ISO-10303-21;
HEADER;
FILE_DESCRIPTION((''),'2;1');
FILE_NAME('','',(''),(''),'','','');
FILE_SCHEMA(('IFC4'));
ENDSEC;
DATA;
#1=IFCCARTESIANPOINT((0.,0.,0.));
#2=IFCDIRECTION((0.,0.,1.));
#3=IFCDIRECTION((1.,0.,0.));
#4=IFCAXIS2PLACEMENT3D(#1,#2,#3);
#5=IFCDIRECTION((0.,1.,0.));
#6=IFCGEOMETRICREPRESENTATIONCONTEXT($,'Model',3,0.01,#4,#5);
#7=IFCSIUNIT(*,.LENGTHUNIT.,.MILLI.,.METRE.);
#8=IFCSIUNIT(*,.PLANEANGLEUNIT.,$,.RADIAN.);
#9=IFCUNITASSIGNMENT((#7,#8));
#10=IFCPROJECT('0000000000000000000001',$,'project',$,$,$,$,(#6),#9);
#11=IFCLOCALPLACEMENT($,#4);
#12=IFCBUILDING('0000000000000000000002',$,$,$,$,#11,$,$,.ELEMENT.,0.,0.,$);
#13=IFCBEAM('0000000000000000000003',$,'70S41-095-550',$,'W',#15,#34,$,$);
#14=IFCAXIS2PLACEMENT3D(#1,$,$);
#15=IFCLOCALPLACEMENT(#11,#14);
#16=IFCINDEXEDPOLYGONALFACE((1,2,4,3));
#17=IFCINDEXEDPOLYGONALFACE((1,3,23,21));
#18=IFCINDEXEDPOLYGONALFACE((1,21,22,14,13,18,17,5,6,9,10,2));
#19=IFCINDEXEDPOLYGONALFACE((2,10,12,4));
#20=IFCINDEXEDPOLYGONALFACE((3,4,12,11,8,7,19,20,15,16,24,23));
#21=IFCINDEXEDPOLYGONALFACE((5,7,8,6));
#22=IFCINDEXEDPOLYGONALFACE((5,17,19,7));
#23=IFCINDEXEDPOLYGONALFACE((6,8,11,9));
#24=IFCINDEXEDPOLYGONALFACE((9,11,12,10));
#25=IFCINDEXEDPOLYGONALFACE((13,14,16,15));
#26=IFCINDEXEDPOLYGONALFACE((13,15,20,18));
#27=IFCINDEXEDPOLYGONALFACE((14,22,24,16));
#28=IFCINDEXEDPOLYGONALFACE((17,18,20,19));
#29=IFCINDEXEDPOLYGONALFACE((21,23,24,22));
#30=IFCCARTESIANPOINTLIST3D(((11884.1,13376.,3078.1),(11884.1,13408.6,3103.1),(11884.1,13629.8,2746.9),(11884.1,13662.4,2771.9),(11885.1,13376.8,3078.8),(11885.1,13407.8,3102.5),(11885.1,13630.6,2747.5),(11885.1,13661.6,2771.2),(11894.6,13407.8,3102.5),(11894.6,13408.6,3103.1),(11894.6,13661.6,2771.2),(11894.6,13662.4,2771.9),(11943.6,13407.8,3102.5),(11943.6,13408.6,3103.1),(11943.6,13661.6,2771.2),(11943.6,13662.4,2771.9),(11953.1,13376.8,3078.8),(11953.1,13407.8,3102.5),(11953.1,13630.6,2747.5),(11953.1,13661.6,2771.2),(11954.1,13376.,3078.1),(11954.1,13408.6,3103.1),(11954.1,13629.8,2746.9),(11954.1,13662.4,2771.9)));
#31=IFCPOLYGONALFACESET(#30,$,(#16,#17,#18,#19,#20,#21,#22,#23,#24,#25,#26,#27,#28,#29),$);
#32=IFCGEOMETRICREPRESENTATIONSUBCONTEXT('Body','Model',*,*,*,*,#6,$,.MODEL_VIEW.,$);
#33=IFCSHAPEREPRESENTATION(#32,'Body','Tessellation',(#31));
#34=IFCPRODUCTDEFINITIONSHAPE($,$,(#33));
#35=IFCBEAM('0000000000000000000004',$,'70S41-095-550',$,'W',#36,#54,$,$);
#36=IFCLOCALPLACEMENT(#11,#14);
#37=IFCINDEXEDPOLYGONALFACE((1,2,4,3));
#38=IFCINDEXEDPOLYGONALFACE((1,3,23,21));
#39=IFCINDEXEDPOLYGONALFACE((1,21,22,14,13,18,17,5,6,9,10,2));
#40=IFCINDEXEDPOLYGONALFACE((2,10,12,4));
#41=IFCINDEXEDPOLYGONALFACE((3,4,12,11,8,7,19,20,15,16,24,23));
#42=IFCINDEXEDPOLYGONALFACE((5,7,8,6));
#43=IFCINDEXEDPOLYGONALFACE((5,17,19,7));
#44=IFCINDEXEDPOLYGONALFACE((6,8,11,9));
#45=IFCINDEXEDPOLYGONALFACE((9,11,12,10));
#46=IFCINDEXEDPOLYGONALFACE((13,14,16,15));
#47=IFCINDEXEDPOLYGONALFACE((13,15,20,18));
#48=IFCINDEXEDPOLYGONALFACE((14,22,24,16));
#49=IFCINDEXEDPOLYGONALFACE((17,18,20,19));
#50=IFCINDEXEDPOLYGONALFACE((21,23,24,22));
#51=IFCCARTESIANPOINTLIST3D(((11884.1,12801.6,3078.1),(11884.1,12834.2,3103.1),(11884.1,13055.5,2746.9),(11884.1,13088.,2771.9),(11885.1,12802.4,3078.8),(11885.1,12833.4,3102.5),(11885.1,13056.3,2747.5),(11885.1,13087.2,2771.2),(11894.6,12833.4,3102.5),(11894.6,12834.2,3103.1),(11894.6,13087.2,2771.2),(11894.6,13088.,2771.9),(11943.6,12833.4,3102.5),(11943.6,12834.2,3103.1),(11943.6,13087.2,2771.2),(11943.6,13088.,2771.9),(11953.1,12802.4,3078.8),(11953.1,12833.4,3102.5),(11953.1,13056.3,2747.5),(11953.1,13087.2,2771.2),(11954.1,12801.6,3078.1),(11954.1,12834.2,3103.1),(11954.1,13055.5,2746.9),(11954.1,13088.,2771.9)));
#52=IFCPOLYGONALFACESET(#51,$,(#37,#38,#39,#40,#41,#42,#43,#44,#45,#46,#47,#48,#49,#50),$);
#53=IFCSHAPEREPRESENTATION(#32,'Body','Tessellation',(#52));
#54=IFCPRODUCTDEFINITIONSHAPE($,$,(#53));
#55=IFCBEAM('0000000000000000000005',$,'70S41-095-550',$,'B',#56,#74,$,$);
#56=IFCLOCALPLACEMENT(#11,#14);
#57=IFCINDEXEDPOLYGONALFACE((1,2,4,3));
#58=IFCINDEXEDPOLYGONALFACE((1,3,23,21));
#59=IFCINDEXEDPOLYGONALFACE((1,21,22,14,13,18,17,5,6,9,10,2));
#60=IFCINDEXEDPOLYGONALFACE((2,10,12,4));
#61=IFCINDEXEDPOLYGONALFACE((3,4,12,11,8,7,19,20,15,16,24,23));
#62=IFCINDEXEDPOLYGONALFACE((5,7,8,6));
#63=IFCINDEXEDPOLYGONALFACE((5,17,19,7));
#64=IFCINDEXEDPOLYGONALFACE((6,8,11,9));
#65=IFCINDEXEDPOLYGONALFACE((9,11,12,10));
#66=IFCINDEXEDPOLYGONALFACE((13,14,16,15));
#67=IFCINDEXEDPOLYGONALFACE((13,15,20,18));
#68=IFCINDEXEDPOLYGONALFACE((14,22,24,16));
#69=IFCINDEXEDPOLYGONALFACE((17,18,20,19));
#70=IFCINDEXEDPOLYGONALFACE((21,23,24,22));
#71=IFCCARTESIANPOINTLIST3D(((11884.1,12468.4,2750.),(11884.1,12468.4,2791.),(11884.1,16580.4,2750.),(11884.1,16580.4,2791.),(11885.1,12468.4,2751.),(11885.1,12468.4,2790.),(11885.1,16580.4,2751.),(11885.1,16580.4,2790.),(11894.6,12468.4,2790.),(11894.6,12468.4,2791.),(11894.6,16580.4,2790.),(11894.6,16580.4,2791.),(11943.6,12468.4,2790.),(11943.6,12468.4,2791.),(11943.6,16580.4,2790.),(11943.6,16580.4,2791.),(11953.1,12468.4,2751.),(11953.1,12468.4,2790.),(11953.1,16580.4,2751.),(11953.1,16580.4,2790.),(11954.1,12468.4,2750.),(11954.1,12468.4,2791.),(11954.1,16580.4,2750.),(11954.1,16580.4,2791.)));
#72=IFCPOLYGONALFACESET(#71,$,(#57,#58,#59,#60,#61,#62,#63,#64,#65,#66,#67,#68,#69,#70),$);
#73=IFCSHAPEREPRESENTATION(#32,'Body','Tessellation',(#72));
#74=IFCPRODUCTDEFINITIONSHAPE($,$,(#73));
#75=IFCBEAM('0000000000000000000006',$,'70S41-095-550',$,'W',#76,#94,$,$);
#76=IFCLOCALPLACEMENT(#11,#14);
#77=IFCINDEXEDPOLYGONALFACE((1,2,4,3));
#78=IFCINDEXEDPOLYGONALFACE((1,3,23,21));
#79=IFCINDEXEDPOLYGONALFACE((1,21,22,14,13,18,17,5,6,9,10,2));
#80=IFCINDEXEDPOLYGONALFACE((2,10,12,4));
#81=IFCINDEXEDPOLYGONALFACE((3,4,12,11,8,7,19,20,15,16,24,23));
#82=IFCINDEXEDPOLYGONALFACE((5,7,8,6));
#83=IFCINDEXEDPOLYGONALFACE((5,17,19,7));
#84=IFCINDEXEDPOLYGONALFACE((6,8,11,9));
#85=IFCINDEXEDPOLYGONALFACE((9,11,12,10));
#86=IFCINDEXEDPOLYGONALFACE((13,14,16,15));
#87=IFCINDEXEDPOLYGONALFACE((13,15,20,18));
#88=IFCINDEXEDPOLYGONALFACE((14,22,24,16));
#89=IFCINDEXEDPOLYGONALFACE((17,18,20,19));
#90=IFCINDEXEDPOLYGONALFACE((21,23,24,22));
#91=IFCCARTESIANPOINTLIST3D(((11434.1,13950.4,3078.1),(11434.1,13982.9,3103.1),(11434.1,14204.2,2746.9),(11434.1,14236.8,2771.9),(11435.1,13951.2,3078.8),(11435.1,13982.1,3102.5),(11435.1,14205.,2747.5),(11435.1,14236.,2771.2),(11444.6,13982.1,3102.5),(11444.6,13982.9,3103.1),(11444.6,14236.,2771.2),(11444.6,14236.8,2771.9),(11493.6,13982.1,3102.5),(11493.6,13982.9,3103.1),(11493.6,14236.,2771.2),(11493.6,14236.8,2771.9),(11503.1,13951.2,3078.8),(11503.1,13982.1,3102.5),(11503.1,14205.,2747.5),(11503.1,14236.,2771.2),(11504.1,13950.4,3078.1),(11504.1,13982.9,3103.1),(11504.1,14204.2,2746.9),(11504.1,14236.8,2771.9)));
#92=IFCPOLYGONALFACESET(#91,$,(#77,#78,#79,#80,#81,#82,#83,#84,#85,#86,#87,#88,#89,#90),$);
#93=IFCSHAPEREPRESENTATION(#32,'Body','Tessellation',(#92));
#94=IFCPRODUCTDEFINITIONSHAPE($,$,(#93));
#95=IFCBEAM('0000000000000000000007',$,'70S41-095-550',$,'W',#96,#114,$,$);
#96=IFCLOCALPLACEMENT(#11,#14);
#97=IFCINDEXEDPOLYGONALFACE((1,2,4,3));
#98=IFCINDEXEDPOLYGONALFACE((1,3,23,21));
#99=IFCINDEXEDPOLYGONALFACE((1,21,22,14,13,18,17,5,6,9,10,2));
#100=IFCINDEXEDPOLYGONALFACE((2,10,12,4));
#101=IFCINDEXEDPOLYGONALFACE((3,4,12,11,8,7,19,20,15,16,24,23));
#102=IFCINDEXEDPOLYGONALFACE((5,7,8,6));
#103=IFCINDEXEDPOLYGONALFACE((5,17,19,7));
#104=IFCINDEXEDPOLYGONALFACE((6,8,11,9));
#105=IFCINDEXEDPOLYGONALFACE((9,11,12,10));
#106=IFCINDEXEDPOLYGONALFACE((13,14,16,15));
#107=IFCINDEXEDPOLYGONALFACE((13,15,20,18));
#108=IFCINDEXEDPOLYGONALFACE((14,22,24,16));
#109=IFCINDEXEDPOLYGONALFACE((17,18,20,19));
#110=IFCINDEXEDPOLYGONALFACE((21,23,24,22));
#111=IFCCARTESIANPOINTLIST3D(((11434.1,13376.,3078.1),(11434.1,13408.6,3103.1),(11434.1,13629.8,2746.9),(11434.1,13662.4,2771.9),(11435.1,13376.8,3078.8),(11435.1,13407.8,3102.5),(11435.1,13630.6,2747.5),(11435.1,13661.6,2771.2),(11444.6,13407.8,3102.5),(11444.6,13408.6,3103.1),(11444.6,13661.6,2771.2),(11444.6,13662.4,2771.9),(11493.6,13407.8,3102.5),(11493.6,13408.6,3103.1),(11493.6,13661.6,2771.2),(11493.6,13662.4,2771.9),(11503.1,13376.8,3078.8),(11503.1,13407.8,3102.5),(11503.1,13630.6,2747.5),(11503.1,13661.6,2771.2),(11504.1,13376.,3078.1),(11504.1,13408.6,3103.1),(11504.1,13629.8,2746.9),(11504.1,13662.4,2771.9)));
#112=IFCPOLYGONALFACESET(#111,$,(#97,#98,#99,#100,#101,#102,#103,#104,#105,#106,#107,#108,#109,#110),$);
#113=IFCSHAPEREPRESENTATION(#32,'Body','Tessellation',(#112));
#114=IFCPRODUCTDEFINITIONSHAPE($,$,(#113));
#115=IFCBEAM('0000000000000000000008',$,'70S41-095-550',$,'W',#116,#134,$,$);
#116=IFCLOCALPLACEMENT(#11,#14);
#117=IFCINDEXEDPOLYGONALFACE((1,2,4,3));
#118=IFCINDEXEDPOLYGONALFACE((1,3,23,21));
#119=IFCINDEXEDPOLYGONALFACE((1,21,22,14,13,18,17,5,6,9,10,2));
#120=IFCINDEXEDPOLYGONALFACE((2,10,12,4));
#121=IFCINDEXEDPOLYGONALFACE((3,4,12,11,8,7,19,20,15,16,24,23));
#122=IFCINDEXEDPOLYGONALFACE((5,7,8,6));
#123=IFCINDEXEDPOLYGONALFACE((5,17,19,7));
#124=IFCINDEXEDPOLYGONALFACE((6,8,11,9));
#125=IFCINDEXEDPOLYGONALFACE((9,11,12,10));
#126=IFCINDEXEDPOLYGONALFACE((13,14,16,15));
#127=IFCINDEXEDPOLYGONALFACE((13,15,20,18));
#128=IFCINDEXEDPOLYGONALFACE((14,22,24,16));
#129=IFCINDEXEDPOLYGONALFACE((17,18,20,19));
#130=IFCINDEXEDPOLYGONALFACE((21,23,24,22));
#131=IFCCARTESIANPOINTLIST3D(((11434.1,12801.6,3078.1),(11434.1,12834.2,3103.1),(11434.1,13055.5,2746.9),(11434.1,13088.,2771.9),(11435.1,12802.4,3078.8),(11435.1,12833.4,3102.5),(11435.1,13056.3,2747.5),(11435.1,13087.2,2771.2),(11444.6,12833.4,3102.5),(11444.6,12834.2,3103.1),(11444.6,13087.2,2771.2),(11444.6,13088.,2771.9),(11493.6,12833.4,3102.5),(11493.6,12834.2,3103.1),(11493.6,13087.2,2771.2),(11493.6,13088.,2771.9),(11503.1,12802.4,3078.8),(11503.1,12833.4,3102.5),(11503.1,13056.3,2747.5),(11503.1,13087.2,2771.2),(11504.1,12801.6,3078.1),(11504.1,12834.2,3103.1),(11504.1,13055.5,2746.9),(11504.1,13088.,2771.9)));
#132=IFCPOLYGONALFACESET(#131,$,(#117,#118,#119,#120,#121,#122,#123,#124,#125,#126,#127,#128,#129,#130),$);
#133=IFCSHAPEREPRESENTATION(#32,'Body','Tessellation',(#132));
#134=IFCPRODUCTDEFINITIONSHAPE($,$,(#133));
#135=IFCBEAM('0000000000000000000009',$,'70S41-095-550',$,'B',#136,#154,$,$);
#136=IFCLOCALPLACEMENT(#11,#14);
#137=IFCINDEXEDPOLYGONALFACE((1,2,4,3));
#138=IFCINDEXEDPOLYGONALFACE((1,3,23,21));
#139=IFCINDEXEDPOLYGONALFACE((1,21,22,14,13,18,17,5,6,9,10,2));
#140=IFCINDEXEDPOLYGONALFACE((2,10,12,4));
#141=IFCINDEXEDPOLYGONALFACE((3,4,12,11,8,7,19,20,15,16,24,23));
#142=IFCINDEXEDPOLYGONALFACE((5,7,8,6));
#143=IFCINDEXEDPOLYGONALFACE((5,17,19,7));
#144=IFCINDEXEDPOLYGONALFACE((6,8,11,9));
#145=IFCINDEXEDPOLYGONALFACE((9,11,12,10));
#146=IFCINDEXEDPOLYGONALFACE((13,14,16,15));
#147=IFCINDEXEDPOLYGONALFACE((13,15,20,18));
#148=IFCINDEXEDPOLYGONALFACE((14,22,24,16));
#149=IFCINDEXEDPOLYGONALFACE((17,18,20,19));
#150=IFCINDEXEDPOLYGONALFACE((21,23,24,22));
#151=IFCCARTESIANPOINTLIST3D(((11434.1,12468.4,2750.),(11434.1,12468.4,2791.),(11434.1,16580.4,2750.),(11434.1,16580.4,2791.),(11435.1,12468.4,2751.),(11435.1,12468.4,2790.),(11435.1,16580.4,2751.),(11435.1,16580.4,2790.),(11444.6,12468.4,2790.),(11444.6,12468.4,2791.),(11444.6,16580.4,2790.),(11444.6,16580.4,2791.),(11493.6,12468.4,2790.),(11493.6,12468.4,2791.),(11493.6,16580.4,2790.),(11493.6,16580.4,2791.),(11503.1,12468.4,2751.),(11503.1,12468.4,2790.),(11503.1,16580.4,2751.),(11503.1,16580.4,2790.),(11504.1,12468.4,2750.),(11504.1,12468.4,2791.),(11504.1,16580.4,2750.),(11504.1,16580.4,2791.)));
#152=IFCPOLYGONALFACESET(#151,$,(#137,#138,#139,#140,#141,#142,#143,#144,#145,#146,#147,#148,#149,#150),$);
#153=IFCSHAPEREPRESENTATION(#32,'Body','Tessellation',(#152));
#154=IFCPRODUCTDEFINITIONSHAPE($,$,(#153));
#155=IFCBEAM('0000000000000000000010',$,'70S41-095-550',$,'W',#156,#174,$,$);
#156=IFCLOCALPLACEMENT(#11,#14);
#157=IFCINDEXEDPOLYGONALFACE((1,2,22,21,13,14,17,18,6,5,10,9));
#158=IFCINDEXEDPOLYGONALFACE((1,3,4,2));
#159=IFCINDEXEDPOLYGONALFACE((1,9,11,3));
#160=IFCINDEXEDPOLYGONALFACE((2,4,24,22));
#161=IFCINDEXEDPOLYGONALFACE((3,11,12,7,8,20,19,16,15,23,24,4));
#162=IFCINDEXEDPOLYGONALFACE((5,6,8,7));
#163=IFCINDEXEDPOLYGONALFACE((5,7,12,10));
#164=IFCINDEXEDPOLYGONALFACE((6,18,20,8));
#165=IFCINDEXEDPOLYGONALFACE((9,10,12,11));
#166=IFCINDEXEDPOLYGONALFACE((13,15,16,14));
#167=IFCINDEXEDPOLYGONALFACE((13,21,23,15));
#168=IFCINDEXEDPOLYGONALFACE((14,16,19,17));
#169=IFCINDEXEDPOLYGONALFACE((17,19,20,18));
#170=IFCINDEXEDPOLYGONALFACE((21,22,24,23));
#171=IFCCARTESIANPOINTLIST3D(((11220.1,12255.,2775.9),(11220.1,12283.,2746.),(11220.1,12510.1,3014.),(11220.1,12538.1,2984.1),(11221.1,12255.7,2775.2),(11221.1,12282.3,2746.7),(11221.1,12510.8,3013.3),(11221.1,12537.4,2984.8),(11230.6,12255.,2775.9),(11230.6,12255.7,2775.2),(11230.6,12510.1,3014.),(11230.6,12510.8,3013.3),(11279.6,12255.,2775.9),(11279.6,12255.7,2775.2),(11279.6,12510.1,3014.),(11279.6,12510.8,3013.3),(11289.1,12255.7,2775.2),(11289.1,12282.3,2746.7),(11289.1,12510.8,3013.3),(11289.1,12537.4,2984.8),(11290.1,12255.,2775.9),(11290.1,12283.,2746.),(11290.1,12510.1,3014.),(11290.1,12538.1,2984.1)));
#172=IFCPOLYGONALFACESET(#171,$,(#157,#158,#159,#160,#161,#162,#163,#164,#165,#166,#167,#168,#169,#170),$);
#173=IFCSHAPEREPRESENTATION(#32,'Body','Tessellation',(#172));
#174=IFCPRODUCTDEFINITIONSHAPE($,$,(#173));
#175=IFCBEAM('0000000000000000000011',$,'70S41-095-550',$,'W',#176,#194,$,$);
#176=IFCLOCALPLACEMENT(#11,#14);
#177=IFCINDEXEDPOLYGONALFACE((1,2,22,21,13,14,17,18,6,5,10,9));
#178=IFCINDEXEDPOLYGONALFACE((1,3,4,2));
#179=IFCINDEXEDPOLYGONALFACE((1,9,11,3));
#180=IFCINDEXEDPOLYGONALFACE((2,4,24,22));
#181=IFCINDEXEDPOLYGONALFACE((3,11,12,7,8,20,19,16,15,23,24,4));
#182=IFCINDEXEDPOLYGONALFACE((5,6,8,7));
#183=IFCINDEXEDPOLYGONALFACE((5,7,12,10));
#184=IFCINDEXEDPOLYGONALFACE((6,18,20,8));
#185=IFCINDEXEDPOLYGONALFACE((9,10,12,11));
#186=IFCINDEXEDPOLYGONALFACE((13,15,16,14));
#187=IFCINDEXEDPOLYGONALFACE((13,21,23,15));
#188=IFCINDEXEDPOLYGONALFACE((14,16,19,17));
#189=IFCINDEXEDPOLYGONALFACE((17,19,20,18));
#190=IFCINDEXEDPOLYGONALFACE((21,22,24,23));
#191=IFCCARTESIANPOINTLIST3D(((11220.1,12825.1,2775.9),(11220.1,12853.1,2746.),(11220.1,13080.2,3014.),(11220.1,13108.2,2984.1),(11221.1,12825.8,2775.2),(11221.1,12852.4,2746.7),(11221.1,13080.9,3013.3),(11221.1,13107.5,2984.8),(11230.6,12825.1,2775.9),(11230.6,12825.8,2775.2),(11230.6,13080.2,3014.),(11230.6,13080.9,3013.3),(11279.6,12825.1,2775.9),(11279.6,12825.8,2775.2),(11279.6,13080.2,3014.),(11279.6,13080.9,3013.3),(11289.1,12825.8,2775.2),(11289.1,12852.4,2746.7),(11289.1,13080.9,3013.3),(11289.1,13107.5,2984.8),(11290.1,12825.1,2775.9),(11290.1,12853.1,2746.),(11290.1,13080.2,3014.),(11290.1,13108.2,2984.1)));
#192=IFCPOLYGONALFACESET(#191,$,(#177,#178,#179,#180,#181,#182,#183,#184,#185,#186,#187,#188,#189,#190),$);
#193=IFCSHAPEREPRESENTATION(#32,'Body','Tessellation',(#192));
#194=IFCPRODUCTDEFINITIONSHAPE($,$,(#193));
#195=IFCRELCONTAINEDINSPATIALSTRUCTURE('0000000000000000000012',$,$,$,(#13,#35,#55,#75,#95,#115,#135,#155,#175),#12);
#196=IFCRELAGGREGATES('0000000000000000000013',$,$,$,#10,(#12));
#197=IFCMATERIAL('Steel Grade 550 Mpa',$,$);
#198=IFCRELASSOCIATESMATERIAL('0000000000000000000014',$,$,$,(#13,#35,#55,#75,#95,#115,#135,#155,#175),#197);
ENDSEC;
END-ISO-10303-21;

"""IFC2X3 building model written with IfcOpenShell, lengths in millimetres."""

from ifc_helpers import new_model, si_unit, direction, frame, origin, origin_with_axes, origin_2d_with_axis, place, context, subcontext, project, spatial, c_section, extrude, source, transform, mapped, material, element, save


model = new_model("IFC2X3")

# Units and contexts
model_context = context("Model", 3, precision=0.01, world=origin_with_axes(), true_north=direction((0.0, 1.0, 0.0)))
body_context = subcontext(model_context, "Body", "Model", "MODEL_VIEW")
ifc_project = project(units=[si_unit("LENGTHUNIT", "METRE", prefix="MILLI"), si_unit("PLANEANGLEUNIT", "RADIAN")], contexts=[model_context])

# Building
building_placement = place(None, origin_with_axes())
building = spatial("IfcBuilding", under=ifc_project, at=building_placement, CompositionType="ELEMENT", ElevationOfRefHeight=0.0, ElevationOfTerrain=0.0)

# Shared definitions
ifc_material = material(Name="Steel Grade 550 Mpa")

# Beams
shared_shape_1 = source(origin(), body_context, "Body", "SweptSolid", [
    extrude(c_section(Depth=70.0, Width=41.0, WallThickness=1.0, Girth=10.5, at=origin_2d_with_axis()), origin_with_axes(), (0.0, 0.0, 1.0), 417.3),
])
beam_1_placement = place(None, frame((11919.1, 13392.3, 3090.6), z_axis=(0.0, 0.608266, -0.793733), x_axis=(0.0, 0.793733, 0.608266)))
element("IfcBeam", 1, at=beam_1_placement, inside=building, material=ifc_material, Name="70S41-095-550", ObjectType="W", context=body_context, shape_type="MappedRepresentation", body=[
    mapped(shared_shape_1, transform((0.0, 0.0, 0.0), scale=1.0)),
])
shared_shape_2 = source(origin(), body_context, "Body", "SweptSolid", [
    extrude(c_section(Depth=70.0, Width=41.0, WallThickness=1.0, Girth=10.5, at=origin_2d_with_axis()), origin_with_axes(), (0.0, 0.0, 1.0), 417.3),
])
beam_2_placement = place(None, frame((11919.1, 12817.9, 3090.6), z_axis=(0.0, 0.608266, -0.793733), x_axis=(0.0, 0.793733, 0.608266)))
element("IfcBeam", 2, at=beam_2_placement, inside=building, material=ifc_material, Name="70S41-095-550", ObjectType="W", context=body_context, shape_type="MappedRepresentation", body=[
    mapped(shared_shape_2, transform((0.0, 0.0, 0.0), scale=1.0)),
])
shared_shape_3 = source(origin(), body_context, "Body", "SweptSolid", [
    extrude(c_section(Depth=70.0, Width=41.0, WallThickness=1.0, Girth=10.5, at=origin_2d_with_axis()), origin_with_axes(), (0.0, 0.0, 1.0), 4112.0),
])
beam_3_placement = place(None, frame((11919.1, 12468.4, 2770.5), z_axis=(0.0, 1.0, 0.0), x_axis=(0.0, 0.0, 1.0)))
element("IfcBeam", 3, at=beam_3_placement, inside=building, material=ifc_material, Name="70S41-095-550", ObjectType="B", context=body_context, shape_type="MappedRepresentation", body=[
    mapped(shared_shape_3, transform((0.0, 0.0, 0.0), scale=1.0)),
])
shared_shape_4 = source(origin(), body_context, "Body", "SweptSolid", [
    extrude(c_section(Depth=70.0, Width=41.0, WallThickness=1.0, Girth=10.5, at=origin_2d_with_axis()), origin_with_axes(), (0.0, 0.0, 1.0), 417.3),
])
beam_4_placement = place(None, frame((11469.1, 13966.7, 3090.6), z_axis=(0.0, 0.608266, -0.793733), x_axis=(0.0, 0.793733, 0.608266)))
element("IfcBeam", 4, at=beam_4_placement, inside=building, material=ifc_material, Name="70S41-095-550", ObjectType="W", context=body_context, shape_type="MappedRepresentation", body=[
    mapped(shared_shape_4, transform((0.0, 0.0, 0.0), scale=1.0)),
])
shared_shape_5 = source(origin(), body_context, "Body", "SweptSolid", [
    extrude(c_section(Depth=70.0, Width=41.0, WallThickness=1.0, Girth=10.5, at=origin_2d_with_axis()), origin_with_axes(), (0.0, 0.0, 1.0), 417.3),
])
beam_5_placement = place(None, frame((11469.1, 13392.3, 3090.6), z_axis=(0.0, 0.608266, -0.793733), x_axis=(0.0, 0.793733, 0.608266)))
element("IfcBeam", 5, at=beam_5_placement, inside=building, material=ifc_material, Name="70S41-095-550", ObjectType="W", context=body_context, shape_type="MappedRepresentation", body=[
    mapped(shared_shape_5, transform((0.0, 0.0, 0.0), scale=1.0)),
])
shared_shape_6 = source(origin(), body_context, "Body", "SweptSolid", [
    extrude(c_section(Depth=70.0, Width=41.0, WallThickness=1.0, Girth=10.5, at=origin_2d_with_axis()), origin_with_axes(), (0.0, 0.0, 1.0), 417.3),
])
beam_6_placement = place(None, frame((11469.1, 12817.9, 3090.6), z_axis=(0.0, 0.608266, -0.793733), x_axis=(0.0, 0.793733, 0.608266)))
element("IfcBeam", 6, at=beam_6_placement, inside=building, material=ifc_material, Name="70S41-095-550", ObjectType="W", context=body_context, shape_type="MappedRepresentation", body=[
    mapped(shared_shape_6, transform((0.0, 0.0, 0.0), scale=1.0)),
])
shared_shape_7 = source(origin(), body_context, "Body", "SweptSolid", [
    extrude(c_section(Depth=70.0, Width=41.0, WallThickness=1.0, Girth=10.5, at=origin_2d_with_axis()), origin_with_axes(), (0.0, 0.0, 1.0), 4112.0),
])
beam_7_placement = place(None, frame((11469.1, 12468.4, 2770.5), z_axis=(0.0, 1.0, 0.0), x_axis=(0.0, 0.0, 1.0)))
element("IfcBeam", 7, at=beam_7_placement, inside=building, material=ifc_material, Name="70S41-095-550", ObjectType="B", context=body_context, shape_type="MappedRepresentation", body=[
    mapped(shared_shape_7, transform((0.0, 0.0, 0.0), scale=1.0)),
])
shared_shape_8 = source(origin(), body_context, "Body", "SweptSolid", [
    extrude(c_section(Depth=70.0, Width=41.0, WallThickness=1.0, Girth=10.5, at=origin_2d_with_axis()), origin_with_axes(), (0.0, 0.0, 1.0), 349.0),
])
beam_8_placement = place(None, frame((11255.1, 12524.1, 2999.1), z_axis=(0.0, -0.731064, -0.682308), x_axis=(0.0, -0.682308, 0.731064)))
element("IfcBeam", 8, at=beam_8_placement, inside=building, material=ifc_material, Name="70S41-095-550", ObjectType="W", context=body_context, shape_type="MappedRepresentation", body=[
    mapped(shared_shape_8, transform((0.0, 0.0, 0.0), scale=1.0)),
])
shared_shape_9 = source(origin(), body_context, "Body", "SweptSolid", [
    extrude(c_section(Depth=70.0, Width=41.0, WallThickness=1.0, Girth=10.5, at=origin_2d_with_axis()), origin_with_axes(), (0.0, 0.0, 1.0), 349.0),
])
beam_9_placement = place(None, frame((11255.1, 13094.2, 2999.1), z_axis=(0.0, -0.731064, -0.682308), x_axis=(0.0, -0.682308, 0.731064)))
element("IfcBeam", 9, at=beam_9_placement, inside=building, material=ifc_material, Name="70S41-095-550", ObjectType="W", context=body_context, shape_type="MappedRepresentation", body=[
    mapped(shared_shape_9, transform((0.0, 0.0, 0.0), scale=1.0)),
])

save(model, "model.ifc")
